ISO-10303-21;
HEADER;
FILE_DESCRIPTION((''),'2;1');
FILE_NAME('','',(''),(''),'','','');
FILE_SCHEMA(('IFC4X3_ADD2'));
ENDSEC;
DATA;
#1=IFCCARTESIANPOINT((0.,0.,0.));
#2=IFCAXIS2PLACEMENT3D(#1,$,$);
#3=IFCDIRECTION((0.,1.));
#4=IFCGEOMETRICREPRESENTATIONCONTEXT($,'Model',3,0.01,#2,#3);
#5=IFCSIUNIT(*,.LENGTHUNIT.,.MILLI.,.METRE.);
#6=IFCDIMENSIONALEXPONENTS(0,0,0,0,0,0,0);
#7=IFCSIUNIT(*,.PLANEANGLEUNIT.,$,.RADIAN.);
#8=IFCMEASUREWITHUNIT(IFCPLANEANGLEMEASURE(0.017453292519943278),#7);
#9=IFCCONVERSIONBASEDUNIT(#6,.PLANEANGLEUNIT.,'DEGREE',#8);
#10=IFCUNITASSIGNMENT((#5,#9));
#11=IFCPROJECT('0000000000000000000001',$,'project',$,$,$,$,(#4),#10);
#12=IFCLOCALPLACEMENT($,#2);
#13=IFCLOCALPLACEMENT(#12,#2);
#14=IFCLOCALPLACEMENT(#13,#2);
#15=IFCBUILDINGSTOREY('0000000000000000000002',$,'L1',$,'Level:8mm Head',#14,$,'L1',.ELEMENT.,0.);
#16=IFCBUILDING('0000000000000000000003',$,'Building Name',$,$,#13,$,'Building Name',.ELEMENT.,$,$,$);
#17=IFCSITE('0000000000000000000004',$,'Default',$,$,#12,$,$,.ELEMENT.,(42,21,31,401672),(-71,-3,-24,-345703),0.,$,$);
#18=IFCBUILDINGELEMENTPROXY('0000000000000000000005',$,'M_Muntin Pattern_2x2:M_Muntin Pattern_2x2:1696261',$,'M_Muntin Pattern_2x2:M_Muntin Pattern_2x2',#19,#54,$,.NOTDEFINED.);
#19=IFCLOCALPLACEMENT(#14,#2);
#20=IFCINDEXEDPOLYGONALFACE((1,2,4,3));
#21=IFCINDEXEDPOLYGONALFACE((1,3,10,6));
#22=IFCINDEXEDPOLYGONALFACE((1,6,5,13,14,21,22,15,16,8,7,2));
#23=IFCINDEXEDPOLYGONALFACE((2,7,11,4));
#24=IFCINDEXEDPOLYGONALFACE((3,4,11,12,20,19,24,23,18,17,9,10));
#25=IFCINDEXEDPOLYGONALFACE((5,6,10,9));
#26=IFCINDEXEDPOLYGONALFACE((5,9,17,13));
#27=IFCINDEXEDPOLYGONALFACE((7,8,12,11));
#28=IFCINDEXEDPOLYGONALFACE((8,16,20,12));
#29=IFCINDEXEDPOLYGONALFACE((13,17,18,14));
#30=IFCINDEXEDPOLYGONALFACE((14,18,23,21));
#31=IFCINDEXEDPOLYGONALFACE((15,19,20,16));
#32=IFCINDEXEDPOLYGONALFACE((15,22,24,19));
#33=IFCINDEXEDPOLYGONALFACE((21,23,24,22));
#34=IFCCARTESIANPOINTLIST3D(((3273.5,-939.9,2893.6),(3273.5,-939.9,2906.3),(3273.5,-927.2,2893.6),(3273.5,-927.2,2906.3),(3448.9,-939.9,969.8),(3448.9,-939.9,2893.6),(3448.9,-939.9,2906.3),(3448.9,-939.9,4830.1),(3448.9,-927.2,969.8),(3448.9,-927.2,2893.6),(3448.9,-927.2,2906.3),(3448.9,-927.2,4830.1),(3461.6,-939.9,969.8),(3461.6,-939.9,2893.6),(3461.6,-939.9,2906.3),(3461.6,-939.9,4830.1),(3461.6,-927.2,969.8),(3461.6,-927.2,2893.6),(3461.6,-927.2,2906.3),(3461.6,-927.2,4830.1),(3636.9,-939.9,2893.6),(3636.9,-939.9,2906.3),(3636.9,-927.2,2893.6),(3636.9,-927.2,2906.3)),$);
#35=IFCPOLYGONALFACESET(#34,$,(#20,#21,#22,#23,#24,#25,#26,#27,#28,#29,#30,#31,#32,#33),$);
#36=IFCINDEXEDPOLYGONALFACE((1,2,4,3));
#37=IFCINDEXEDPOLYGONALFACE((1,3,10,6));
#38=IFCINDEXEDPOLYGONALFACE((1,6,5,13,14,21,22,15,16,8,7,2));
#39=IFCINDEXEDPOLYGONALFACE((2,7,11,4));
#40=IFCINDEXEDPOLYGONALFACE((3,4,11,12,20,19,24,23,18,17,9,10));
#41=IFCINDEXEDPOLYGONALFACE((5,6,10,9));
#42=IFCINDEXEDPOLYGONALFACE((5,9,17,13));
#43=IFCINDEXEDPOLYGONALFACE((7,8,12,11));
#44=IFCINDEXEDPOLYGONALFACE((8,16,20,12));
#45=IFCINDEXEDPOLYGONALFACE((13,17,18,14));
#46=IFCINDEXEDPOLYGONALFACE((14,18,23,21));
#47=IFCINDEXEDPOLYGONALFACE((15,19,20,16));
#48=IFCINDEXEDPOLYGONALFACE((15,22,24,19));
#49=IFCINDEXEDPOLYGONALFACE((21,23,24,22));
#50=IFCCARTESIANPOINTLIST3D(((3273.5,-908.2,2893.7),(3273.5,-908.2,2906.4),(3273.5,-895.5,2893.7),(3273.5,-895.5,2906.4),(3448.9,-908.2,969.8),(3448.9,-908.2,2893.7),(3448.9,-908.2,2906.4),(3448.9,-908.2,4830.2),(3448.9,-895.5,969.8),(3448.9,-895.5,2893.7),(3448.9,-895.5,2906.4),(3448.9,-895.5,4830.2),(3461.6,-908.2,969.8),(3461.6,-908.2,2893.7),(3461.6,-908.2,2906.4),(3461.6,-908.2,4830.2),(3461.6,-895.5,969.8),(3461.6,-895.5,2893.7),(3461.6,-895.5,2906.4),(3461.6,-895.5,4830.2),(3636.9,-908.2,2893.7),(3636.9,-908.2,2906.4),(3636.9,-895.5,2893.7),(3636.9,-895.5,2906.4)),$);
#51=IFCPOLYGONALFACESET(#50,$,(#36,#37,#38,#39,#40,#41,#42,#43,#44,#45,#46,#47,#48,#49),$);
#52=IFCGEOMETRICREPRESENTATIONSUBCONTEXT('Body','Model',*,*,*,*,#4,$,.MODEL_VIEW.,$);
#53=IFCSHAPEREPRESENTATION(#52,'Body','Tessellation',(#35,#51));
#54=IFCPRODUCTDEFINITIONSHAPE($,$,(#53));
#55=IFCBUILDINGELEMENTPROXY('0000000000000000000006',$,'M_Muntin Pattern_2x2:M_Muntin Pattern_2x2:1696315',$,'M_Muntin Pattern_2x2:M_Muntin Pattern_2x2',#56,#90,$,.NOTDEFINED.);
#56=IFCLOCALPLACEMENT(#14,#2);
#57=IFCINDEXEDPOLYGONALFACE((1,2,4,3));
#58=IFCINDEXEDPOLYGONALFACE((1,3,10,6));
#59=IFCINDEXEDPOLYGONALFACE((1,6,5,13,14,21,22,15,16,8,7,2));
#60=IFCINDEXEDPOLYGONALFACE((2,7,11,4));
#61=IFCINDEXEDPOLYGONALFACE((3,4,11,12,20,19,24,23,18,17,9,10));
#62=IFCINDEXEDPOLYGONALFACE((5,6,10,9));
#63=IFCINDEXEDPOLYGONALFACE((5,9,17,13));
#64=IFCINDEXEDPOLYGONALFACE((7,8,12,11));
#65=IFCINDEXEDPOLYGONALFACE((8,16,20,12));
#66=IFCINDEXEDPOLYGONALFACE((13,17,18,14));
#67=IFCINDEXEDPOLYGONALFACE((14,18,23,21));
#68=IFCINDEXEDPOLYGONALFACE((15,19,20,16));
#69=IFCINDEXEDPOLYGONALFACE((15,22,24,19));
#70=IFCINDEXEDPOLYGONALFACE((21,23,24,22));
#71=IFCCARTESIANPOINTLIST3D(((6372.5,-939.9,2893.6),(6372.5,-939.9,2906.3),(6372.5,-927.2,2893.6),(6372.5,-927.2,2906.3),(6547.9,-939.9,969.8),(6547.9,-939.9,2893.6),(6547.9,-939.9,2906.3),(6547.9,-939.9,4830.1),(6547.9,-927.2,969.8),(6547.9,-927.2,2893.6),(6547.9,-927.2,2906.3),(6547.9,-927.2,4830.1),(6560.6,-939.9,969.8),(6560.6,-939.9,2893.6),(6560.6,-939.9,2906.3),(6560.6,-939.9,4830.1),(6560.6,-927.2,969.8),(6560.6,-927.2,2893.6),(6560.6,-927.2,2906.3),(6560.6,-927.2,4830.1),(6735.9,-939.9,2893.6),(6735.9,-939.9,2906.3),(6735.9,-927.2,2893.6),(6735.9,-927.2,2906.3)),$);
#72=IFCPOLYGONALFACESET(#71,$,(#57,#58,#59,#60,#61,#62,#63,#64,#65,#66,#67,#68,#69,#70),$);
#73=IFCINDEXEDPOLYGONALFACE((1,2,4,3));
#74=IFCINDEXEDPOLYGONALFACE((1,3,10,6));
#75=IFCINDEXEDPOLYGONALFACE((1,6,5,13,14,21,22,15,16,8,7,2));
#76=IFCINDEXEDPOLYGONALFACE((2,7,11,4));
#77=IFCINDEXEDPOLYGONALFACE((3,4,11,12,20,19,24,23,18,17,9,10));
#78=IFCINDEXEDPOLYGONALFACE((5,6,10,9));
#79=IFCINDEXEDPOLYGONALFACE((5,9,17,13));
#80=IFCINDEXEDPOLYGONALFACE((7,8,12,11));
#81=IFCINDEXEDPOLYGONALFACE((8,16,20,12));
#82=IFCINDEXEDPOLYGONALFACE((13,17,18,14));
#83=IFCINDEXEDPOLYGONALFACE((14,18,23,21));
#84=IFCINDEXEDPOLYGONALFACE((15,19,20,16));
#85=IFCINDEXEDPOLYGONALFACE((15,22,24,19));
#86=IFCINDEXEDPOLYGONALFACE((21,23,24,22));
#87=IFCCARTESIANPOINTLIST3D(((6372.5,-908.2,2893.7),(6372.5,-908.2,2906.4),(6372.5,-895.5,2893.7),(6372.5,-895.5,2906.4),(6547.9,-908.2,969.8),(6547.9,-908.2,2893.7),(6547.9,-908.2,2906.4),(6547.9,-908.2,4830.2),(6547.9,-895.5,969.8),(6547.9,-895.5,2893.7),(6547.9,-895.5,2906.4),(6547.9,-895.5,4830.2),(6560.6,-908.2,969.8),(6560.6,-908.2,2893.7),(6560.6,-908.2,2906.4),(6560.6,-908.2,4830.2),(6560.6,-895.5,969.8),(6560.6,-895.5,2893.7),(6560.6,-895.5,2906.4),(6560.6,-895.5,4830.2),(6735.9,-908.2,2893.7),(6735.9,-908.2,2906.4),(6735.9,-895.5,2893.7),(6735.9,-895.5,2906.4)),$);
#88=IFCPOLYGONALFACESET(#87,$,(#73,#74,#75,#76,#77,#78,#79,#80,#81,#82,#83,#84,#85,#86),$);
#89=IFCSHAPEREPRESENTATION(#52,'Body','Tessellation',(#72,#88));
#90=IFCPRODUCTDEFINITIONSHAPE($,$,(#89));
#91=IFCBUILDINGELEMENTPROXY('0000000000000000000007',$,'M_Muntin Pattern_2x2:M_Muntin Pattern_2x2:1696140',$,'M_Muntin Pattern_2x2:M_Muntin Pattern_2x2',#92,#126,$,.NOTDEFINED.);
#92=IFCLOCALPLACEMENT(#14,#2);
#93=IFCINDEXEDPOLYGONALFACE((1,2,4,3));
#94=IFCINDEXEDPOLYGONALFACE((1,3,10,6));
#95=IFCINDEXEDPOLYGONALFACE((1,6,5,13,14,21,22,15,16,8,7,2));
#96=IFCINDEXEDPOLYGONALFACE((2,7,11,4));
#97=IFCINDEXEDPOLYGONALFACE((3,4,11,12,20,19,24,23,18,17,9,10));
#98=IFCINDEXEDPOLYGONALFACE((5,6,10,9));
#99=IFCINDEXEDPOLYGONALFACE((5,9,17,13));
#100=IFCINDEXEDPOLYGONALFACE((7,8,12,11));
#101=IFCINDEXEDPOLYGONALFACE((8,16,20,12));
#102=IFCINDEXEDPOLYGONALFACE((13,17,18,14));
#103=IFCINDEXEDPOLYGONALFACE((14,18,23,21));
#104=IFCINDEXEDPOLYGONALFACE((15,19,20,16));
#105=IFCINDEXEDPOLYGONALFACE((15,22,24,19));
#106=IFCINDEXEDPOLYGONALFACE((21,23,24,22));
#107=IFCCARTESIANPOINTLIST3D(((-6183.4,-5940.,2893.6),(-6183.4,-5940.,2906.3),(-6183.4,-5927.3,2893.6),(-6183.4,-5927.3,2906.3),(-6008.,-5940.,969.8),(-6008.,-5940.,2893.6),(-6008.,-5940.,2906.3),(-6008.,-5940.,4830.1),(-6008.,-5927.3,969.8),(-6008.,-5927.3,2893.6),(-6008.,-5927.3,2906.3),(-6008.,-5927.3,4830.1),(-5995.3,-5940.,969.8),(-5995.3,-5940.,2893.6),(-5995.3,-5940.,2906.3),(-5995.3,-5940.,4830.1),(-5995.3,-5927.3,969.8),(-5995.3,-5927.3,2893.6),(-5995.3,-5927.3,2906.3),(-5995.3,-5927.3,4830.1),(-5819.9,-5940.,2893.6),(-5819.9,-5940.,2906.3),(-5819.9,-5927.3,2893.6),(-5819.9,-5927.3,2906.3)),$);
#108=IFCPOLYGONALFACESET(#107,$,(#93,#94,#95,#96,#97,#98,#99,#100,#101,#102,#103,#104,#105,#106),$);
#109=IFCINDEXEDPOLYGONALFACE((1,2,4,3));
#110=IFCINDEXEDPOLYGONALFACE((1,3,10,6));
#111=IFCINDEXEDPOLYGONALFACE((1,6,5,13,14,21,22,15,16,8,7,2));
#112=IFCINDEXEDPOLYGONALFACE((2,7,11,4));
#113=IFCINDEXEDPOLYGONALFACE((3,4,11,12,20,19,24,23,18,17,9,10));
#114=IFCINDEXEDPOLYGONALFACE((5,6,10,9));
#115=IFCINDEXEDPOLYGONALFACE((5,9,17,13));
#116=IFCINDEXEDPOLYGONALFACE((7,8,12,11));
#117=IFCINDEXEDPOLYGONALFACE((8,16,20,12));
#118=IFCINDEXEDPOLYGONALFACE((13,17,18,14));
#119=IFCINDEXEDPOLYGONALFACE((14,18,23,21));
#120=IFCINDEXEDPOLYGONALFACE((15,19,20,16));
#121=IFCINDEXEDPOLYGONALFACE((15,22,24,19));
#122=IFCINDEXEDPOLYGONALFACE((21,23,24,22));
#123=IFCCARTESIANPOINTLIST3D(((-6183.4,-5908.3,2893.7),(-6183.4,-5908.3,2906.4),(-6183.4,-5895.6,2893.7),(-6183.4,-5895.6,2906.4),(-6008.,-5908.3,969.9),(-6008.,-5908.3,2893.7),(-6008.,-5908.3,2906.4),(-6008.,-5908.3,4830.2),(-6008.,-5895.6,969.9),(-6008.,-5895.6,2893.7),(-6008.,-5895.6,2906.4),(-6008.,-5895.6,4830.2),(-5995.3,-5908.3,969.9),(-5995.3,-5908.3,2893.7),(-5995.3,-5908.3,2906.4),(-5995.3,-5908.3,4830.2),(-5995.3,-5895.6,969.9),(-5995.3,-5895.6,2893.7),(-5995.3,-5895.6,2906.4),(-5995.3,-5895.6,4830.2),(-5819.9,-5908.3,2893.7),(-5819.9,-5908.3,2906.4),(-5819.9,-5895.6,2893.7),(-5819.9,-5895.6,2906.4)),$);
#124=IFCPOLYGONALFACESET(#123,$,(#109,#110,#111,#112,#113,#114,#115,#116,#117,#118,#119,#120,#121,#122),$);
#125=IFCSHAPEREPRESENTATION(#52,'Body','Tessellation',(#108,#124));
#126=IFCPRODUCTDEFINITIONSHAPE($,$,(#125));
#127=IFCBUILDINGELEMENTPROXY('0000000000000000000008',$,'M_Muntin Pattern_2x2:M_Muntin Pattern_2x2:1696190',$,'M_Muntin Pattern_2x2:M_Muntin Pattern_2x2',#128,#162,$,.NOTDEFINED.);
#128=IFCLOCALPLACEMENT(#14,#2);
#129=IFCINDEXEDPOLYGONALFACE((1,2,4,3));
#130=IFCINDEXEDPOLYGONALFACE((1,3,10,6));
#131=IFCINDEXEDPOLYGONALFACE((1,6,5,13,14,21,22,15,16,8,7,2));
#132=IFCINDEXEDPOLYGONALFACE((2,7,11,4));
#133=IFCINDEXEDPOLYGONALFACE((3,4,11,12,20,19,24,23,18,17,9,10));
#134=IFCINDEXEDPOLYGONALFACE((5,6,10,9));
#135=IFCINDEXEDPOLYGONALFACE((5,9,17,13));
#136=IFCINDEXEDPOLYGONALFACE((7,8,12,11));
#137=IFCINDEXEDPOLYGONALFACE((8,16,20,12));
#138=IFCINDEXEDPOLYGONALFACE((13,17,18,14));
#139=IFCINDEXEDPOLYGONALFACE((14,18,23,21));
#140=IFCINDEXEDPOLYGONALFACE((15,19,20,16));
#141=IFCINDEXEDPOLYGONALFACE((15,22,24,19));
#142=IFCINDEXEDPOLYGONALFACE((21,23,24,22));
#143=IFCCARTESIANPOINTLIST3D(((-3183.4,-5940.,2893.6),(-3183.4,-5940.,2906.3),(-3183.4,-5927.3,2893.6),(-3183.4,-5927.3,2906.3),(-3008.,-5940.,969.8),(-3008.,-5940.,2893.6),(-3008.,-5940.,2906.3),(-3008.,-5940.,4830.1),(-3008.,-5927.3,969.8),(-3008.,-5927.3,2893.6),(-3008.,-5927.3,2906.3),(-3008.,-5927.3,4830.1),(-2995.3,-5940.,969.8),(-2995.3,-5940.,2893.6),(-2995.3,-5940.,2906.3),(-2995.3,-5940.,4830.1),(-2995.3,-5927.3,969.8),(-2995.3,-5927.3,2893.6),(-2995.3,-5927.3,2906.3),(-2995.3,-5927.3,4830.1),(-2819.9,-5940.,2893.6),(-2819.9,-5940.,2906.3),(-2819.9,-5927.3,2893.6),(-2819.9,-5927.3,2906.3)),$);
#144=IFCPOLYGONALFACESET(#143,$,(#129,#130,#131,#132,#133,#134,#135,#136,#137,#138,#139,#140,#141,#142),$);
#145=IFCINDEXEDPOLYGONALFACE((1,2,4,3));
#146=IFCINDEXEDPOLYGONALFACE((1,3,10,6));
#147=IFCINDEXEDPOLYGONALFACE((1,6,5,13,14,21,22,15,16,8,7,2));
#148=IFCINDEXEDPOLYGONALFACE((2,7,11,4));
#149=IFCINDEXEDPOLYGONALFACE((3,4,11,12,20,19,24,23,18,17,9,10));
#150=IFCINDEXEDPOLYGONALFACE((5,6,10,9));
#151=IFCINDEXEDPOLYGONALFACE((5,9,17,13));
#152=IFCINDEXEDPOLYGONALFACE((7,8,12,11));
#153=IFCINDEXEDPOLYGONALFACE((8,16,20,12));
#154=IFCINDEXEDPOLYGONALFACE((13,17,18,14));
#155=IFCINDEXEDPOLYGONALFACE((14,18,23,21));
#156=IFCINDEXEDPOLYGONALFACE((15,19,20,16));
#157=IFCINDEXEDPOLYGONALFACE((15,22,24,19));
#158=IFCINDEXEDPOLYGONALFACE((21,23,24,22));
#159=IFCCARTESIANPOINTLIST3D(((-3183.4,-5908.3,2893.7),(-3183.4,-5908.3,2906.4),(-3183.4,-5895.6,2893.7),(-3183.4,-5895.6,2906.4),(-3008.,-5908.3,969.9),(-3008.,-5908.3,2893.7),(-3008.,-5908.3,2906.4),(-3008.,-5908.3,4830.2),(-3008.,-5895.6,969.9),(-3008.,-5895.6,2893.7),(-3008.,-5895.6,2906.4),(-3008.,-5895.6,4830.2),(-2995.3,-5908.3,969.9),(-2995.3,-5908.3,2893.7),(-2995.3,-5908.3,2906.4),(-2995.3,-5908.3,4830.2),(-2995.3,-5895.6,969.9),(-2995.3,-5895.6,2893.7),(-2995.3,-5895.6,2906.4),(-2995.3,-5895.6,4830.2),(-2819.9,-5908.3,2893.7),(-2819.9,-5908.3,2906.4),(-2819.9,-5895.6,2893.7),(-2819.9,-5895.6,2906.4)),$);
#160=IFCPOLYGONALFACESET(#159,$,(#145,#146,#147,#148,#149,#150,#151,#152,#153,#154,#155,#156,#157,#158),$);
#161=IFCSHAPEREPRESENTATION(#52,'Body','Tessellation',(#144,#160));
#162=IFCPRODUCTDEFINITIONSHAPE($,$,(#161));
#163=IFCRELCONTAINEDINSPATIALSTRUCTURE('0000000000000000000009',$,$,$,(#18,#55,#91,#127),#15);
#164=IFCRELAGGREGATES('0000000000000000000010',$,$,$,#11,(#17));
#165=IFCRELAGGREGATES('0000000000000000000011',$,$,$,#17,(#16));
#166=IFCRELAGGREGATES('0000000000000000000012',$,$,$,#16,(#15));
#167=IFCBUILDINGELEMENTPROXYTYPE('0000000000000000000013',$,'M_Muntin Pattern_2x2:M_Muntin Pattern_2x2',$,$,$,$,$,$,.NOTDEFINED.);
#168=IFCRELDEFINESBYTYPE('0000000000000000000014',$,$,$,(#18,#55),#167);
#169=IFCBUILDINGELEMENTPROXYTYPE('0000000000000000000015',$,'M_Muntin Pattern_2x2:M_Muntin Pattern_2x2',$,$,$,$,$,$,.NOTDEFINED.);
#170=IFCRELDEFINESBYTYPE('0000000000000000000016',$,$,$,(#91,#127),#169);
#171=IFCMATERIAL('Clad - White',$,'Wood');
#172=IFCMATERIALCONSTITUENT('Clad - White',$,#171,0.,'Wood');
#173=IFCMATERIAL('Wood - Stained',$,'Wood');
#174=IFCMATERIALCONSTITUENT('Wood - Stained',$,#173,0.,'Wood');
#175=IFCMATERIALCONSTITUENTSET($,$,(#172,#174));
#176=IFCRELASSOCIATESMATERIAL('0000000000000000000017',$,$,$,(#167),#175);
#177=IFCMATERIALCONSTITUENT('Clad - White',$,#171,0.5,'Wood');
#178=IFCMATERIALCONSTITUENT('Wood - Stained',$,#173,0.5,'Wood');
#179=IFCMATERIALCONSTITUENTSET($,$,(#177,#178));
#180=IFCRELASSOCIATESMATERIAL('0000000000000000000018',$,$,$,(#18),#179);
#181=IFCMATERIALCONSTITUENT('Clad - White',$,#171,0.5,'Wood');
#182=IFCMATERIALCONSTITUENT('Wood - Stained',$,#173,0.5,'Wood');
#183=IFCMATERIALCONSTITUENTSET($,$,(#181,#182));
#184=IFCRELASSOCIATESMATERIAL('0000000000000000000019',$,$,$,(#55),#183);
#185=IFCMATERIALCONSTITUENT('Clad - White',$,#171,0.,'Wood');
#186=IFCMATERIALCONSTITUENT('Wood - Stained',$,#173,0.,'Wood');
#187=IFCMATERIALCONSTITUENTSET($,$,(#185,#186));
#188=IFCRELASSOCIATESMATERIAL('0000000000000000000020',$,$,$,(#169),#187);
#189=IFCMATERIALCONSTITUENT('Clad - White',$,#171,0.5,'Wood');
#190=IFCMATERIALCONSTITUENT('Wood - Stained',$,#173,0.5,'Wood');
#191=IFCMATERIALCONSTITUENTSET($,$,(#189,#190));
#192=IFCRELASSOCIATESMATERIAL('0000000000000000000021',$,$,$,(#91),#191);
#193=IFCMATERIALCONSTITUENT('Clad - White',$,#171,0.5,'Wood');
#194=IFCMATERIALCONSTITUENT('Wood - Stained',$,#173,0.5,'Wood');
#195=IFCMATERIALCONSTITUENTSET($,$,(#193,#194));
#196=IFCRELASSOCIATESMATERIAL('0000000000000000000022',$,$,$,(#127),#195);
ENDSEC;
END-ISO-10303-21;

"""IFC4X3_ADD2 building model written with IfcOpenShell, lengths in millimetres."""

from ifc_helpers import new_model, entity, si_unit, converted_unit, direction, frame, origin, place, context, subcontext, project, spatial, polyline, outline, extrude, source, transform, mapped, material, constituent, constituent_set, type_object, type_shapes, element, save


model = new_model("IFC4X3_ADD2")

# Units and contexts
model_context = context("Model", 3, precision=0.01, world=origin(), true_north=direction((0.0, 1.0)))
body_context = subcontext(model_context, "Body", "Model", "MODEL_VIEW")
ifc_project = project(units=[si_unit("LENGTHUNIT", "METRE", prefix="MILLI"), converted_unit("PLANEANGLEUNIT", "DEGREE", entity("IfcPlaneAngleMeasure", 0.017453292519943278), si_unit("PLANEANGLEUNIT", "RADIAN"), dimensions=[0, 0, 0, 0, 0, 0, 0])], contexts=[model_context])

# Site, building, storey
site_placement = place(None, origin())
site = spatial("IfcSite", under=ifc_project, at=site_placement, Name="Default", CompositionType="ELEMENT", RefLatitude=(42, 21, 31, 401672), RefLongitude=(-71, -3, -24, -345703), RefElevation=0.0)
building_placement = place(site_placement, origin())
building = spatial("IfcBuilding", under=site, at=building_placement, Name="Building Name", LongName="Building Name", CompositionType="ELEMENT")
storey_placement = place(building_placement, origin())
storey = spatial("IfcBuildingStorey", under=building, at=storey_placement, Name="L1", ObjectType="Level:8mm Head", LongName="L1", CompositionType="ELEMENT", Elevation=0.0)

# Building element proxies
ifc_material_1 = material(Name="Clad - White", Category="Wood")
ifc_material_2 = material(Name="Wood - Stained", Category="Wood")
ifc_constituent_1 = constituent(ifc_material_1, Name="Clad - White", Category="Wood", fraction=0.0)
ifc_constituent_2 = constituent(ifc_material_2, Name="Wood - Stained", Category="Wood", fraction=0.0)
ifc_constituent_set_1 = constituent_set(constituents=[ifc_constituent_1, ifc_constituent_2])
building_element_proxy_type_1 = type_object("IfcBuildingElementProxyType", Name="M_Muntin Pattern_2x2:M_Muntin Pattern_2x2", PredefinedType="NOTDEFINED", material=ifc_constituent_set_1)
shared_shape_1 = source(origin(), body_context, "Body", "SweptSolid", [
    extrude(outline(polyline([(6.4, -6.4), (1930.1, -6.4), (1930.1, 6.3), (6.4, 6.3), (6.4, 181.7), (-6.3, 181.7), (-6.3, 6.3), (-1930.2, 6.3), (-1930.2, -6.4), (-6.3, -6.4), (-6.3, -181.7), (6.4, -181.7), (6.4, -6.4)])), frame((0.0, 9.5, 1930.1), z_axis=(0.0, 1.0, 0.0), x_axis=(0.0, 0.0, 1.0)), (0.0, 0.0, 1.0), 12.7),
    extrude(outline(polyline([(6.4, -6.4), (1930.2, -6.4), (1930.2, 6.3), (6.4, 6.3), (6.4, 181.7), (-6.3, 181.7), (-6.3, 6.3), (-1930.2, 6.3), (-1930.2, -6.4), (-6.3, -6.4), (-6.3, -181.7), (6.4, -181.7), (6.4, -6.4)])), frame((0.0, -22.2, 1930.2), z_axis=(0.0, 1.0, 0.0), x_axis=(0.0, 0.0, 1.0)), (0.0, 0.0, 1.0), 12.7),
])
type_shapes(building_element_proxy_type_1, [shared_shape_1])
ifc_constituent_3 = constituent(ifc_material_1, Name="Clad - White", Category="Wood", fraction=0.5)
ifc_constituent_4 = constituent(ifc_material_2, Name="Wood - Stained", Category="Wood", fraction=0.5)
ifc_constituent_set_2 = constituent_set(constituents=[ifc_constituent_3, ifc_constituent_4])
proxy_1_placement = place(storey_placement, frame((3455.2, -917.7, 969.8), z_axis=(0.0, 0.0, 1.0), x_axis=(-1.0, 0.0, 0.0)))
element("IfcBuildingElementProxy", 1, at=proxy_1_placement, inside=storey, type_object=building_element_proxy_type_1, material=ifc_constituent_set_2, Name="M_Muntin Pattern_2x2:M_Muntin Pattern_2x2:1696261", ObjectType="M_Muntin Pattern_2x2:M_Muntin Pattern_2x2", PredefinedType="NOTDEFINED", context=body_context, shape_type="MappedRepresentation", body=[
    mapped(shared_shape_1, transform((0.0, 0.0, 0.0), scale=1.0)),
])
ifc_constituent_5 = constituent(ifc_material_1, Name="Clad - White", Category="Wood", fraction=0.5)
ifc_constituent_6 = constituent(ifc_material_2, Name="Wood - Stained", Category="Wood", fraction=0.5)
ifc_constituent_set_3 = constituent_set(constituents=[ifc_constituent_5, ifc_constituent_6])
proxy_2_placement = place(storey_placement, frame((6554.2, -917.7, 969.8), z_axis=(0.0, 0.0, 1.0), x_axis=(-1.0, 0.0, 0.0)))
element("IfcBuildingElementProxy", 2, at=proxy_2_placement, inside=storey, type_object=building_element_proxy_type_1, material=ifc_constituent_set_3, Name="M_Muntin Pattern_2x2:M_Muntin Pattern_2x2:1696315", ObjectType="M_Muntin Pattern_2x2:M_Muntin Pattern_2x2", PredefinedType="NOTDEFINED", context=body_context, shape_type="MappedRepresentation", body=[
    mapped(shared_shape_1, transform((0.0, 0.0, 0.0), scale=1.0)),
])
ifc_constituent_7 = constituent(ifc_material_1, Name="Clad - White", Category="Wood", fraction=0.5)
ifc_constituent_8 = constituent(ifc_material_2, Name="Wood - Stained", Category="Wood", fraction=0.5)
ifc_constituent_set_4 = constituent_set(constituents=[ifc_constituent_7, ifc_constituent_8])
ifc_constituent_9 = constituent(ifc_material_1, Name="Clad - White", Category="Wood", fraction=0.0)
ifc_constituent_10 = constituent(ifc_material_2, Name="Wood - Stained", Category="Wood", fraction=0.0)
ifc_constituent_set_5 = constituent_set(constituents=[ifc_constituent_9, ifc_constituent_10])
building_element_proxy_type_2 = type_object("IfcBuildingElementProxyType", Name="M_Muntin Pattern_2x2:M_Muntin Pattern_2x2", PredefinedType="NOTDEFINED", material=ifc_constituent_set_5)
shared_shape_2 = source(origin(), body_context, "Body", "SweptSolid", [
    extrude(outline(polyline([(6.4, -6.4), (1930.1, -6.4), (1930.1, 6.3), (6.4, 6.3), (6.4, 181.7), (-6.3, 181.7), (-6.3, 6.3), (-1930.2, 6.3), (-1930.2, -6.4), (-6.3, -6.4), (-6.3, -181.7), (6.4, -181.7), (6.4, -6.4)])), frame((0.0, -22.2, 1930.1), z_axis=(0.0, 1.0, 0.0), x_axis=(0.0, 0.0, 1.0)), (0.0, 0.0, 1.0), 12.7),
    extrude(outline(polyline([(6.4, -6.4), (1930.2, -6.4), (1930.2, 6.3), (6.4, 6.3), (6.4, 181.7), (-6.3, 181.7), (-6.3, 6.3), (-1930.2, 6.3), (-1930.2, -6.4), (-6.3, -6.4), (-6.3, -181.7), (6.4, -181.7), (6.4, -6.4)])), frame((0.0, 9.5, 1930.2), z_axis=(0.0, 1.0, 0.0), x_axis=(0.0, 0.0, 1.0)), (0.0, 0.0, 1.0), 12.7),
])
type_shapes(building_element_proxy_type_2, [shared_shape_2])
proxy_3_placement = place(storey_placement, frame((-6001.6, -5917.8, 969.9)))
element("IfcBuildingElementProxy", 3, at=proxy_3_placement, inside=storey, type_object=building_element_proxy_type_2, material=ifc_constituent_set_4, Name="M_Muntin Pattern_2x2:M_Muntin Pattern_2x2:1696140", ObjectType="M_Muntin Pattern_2x2:M_Muntin Pattern_2x2", PredefinedType="NOTDEFINED", context=body_context, shape_type="MappedRepresentation", body=[
    mapped(shared_shape_2, transform((0.0, 0.0, 0.0), scale=1.0)),
])
ifc_constituent_11 = constituent(ifc_material_1, Name="Clad - White", Category="Wood", fraction=0.5)
ifc_constituent_12 = constituent(ifc_material_2, Name="Wood - Stained", Category="Wood", fraction=0.5)
ifc_constituent_set_6 = constituent_set(constituents=[ifc_constituent_11, ifc_constituent_12])
proxy_4_placement = place(storey_placement, frame((-3001.6, -5917.8, 969.9)))
element("IfcBuildingElementProxy", 4, at=proxy_4_placement, inside=storey, type_object=building_element_proxy_type_2, material=ifc_constituent_set_6, Name="M_Muntin Pattern_2x2:M_Muntin Pattern_2x2:1696190", ObjectType="M_Muntin Pattern_2x2:M_Muntin Pattern_2x2", PredefinedType="NOTDEFINED", context=body_context, shape_type="MappedRepresentation", body=[
    mapped(shared_shape_2, transform((0.0, 0.0, 0.0), scale=1.0)),
])

save(model, "model.ifc")
